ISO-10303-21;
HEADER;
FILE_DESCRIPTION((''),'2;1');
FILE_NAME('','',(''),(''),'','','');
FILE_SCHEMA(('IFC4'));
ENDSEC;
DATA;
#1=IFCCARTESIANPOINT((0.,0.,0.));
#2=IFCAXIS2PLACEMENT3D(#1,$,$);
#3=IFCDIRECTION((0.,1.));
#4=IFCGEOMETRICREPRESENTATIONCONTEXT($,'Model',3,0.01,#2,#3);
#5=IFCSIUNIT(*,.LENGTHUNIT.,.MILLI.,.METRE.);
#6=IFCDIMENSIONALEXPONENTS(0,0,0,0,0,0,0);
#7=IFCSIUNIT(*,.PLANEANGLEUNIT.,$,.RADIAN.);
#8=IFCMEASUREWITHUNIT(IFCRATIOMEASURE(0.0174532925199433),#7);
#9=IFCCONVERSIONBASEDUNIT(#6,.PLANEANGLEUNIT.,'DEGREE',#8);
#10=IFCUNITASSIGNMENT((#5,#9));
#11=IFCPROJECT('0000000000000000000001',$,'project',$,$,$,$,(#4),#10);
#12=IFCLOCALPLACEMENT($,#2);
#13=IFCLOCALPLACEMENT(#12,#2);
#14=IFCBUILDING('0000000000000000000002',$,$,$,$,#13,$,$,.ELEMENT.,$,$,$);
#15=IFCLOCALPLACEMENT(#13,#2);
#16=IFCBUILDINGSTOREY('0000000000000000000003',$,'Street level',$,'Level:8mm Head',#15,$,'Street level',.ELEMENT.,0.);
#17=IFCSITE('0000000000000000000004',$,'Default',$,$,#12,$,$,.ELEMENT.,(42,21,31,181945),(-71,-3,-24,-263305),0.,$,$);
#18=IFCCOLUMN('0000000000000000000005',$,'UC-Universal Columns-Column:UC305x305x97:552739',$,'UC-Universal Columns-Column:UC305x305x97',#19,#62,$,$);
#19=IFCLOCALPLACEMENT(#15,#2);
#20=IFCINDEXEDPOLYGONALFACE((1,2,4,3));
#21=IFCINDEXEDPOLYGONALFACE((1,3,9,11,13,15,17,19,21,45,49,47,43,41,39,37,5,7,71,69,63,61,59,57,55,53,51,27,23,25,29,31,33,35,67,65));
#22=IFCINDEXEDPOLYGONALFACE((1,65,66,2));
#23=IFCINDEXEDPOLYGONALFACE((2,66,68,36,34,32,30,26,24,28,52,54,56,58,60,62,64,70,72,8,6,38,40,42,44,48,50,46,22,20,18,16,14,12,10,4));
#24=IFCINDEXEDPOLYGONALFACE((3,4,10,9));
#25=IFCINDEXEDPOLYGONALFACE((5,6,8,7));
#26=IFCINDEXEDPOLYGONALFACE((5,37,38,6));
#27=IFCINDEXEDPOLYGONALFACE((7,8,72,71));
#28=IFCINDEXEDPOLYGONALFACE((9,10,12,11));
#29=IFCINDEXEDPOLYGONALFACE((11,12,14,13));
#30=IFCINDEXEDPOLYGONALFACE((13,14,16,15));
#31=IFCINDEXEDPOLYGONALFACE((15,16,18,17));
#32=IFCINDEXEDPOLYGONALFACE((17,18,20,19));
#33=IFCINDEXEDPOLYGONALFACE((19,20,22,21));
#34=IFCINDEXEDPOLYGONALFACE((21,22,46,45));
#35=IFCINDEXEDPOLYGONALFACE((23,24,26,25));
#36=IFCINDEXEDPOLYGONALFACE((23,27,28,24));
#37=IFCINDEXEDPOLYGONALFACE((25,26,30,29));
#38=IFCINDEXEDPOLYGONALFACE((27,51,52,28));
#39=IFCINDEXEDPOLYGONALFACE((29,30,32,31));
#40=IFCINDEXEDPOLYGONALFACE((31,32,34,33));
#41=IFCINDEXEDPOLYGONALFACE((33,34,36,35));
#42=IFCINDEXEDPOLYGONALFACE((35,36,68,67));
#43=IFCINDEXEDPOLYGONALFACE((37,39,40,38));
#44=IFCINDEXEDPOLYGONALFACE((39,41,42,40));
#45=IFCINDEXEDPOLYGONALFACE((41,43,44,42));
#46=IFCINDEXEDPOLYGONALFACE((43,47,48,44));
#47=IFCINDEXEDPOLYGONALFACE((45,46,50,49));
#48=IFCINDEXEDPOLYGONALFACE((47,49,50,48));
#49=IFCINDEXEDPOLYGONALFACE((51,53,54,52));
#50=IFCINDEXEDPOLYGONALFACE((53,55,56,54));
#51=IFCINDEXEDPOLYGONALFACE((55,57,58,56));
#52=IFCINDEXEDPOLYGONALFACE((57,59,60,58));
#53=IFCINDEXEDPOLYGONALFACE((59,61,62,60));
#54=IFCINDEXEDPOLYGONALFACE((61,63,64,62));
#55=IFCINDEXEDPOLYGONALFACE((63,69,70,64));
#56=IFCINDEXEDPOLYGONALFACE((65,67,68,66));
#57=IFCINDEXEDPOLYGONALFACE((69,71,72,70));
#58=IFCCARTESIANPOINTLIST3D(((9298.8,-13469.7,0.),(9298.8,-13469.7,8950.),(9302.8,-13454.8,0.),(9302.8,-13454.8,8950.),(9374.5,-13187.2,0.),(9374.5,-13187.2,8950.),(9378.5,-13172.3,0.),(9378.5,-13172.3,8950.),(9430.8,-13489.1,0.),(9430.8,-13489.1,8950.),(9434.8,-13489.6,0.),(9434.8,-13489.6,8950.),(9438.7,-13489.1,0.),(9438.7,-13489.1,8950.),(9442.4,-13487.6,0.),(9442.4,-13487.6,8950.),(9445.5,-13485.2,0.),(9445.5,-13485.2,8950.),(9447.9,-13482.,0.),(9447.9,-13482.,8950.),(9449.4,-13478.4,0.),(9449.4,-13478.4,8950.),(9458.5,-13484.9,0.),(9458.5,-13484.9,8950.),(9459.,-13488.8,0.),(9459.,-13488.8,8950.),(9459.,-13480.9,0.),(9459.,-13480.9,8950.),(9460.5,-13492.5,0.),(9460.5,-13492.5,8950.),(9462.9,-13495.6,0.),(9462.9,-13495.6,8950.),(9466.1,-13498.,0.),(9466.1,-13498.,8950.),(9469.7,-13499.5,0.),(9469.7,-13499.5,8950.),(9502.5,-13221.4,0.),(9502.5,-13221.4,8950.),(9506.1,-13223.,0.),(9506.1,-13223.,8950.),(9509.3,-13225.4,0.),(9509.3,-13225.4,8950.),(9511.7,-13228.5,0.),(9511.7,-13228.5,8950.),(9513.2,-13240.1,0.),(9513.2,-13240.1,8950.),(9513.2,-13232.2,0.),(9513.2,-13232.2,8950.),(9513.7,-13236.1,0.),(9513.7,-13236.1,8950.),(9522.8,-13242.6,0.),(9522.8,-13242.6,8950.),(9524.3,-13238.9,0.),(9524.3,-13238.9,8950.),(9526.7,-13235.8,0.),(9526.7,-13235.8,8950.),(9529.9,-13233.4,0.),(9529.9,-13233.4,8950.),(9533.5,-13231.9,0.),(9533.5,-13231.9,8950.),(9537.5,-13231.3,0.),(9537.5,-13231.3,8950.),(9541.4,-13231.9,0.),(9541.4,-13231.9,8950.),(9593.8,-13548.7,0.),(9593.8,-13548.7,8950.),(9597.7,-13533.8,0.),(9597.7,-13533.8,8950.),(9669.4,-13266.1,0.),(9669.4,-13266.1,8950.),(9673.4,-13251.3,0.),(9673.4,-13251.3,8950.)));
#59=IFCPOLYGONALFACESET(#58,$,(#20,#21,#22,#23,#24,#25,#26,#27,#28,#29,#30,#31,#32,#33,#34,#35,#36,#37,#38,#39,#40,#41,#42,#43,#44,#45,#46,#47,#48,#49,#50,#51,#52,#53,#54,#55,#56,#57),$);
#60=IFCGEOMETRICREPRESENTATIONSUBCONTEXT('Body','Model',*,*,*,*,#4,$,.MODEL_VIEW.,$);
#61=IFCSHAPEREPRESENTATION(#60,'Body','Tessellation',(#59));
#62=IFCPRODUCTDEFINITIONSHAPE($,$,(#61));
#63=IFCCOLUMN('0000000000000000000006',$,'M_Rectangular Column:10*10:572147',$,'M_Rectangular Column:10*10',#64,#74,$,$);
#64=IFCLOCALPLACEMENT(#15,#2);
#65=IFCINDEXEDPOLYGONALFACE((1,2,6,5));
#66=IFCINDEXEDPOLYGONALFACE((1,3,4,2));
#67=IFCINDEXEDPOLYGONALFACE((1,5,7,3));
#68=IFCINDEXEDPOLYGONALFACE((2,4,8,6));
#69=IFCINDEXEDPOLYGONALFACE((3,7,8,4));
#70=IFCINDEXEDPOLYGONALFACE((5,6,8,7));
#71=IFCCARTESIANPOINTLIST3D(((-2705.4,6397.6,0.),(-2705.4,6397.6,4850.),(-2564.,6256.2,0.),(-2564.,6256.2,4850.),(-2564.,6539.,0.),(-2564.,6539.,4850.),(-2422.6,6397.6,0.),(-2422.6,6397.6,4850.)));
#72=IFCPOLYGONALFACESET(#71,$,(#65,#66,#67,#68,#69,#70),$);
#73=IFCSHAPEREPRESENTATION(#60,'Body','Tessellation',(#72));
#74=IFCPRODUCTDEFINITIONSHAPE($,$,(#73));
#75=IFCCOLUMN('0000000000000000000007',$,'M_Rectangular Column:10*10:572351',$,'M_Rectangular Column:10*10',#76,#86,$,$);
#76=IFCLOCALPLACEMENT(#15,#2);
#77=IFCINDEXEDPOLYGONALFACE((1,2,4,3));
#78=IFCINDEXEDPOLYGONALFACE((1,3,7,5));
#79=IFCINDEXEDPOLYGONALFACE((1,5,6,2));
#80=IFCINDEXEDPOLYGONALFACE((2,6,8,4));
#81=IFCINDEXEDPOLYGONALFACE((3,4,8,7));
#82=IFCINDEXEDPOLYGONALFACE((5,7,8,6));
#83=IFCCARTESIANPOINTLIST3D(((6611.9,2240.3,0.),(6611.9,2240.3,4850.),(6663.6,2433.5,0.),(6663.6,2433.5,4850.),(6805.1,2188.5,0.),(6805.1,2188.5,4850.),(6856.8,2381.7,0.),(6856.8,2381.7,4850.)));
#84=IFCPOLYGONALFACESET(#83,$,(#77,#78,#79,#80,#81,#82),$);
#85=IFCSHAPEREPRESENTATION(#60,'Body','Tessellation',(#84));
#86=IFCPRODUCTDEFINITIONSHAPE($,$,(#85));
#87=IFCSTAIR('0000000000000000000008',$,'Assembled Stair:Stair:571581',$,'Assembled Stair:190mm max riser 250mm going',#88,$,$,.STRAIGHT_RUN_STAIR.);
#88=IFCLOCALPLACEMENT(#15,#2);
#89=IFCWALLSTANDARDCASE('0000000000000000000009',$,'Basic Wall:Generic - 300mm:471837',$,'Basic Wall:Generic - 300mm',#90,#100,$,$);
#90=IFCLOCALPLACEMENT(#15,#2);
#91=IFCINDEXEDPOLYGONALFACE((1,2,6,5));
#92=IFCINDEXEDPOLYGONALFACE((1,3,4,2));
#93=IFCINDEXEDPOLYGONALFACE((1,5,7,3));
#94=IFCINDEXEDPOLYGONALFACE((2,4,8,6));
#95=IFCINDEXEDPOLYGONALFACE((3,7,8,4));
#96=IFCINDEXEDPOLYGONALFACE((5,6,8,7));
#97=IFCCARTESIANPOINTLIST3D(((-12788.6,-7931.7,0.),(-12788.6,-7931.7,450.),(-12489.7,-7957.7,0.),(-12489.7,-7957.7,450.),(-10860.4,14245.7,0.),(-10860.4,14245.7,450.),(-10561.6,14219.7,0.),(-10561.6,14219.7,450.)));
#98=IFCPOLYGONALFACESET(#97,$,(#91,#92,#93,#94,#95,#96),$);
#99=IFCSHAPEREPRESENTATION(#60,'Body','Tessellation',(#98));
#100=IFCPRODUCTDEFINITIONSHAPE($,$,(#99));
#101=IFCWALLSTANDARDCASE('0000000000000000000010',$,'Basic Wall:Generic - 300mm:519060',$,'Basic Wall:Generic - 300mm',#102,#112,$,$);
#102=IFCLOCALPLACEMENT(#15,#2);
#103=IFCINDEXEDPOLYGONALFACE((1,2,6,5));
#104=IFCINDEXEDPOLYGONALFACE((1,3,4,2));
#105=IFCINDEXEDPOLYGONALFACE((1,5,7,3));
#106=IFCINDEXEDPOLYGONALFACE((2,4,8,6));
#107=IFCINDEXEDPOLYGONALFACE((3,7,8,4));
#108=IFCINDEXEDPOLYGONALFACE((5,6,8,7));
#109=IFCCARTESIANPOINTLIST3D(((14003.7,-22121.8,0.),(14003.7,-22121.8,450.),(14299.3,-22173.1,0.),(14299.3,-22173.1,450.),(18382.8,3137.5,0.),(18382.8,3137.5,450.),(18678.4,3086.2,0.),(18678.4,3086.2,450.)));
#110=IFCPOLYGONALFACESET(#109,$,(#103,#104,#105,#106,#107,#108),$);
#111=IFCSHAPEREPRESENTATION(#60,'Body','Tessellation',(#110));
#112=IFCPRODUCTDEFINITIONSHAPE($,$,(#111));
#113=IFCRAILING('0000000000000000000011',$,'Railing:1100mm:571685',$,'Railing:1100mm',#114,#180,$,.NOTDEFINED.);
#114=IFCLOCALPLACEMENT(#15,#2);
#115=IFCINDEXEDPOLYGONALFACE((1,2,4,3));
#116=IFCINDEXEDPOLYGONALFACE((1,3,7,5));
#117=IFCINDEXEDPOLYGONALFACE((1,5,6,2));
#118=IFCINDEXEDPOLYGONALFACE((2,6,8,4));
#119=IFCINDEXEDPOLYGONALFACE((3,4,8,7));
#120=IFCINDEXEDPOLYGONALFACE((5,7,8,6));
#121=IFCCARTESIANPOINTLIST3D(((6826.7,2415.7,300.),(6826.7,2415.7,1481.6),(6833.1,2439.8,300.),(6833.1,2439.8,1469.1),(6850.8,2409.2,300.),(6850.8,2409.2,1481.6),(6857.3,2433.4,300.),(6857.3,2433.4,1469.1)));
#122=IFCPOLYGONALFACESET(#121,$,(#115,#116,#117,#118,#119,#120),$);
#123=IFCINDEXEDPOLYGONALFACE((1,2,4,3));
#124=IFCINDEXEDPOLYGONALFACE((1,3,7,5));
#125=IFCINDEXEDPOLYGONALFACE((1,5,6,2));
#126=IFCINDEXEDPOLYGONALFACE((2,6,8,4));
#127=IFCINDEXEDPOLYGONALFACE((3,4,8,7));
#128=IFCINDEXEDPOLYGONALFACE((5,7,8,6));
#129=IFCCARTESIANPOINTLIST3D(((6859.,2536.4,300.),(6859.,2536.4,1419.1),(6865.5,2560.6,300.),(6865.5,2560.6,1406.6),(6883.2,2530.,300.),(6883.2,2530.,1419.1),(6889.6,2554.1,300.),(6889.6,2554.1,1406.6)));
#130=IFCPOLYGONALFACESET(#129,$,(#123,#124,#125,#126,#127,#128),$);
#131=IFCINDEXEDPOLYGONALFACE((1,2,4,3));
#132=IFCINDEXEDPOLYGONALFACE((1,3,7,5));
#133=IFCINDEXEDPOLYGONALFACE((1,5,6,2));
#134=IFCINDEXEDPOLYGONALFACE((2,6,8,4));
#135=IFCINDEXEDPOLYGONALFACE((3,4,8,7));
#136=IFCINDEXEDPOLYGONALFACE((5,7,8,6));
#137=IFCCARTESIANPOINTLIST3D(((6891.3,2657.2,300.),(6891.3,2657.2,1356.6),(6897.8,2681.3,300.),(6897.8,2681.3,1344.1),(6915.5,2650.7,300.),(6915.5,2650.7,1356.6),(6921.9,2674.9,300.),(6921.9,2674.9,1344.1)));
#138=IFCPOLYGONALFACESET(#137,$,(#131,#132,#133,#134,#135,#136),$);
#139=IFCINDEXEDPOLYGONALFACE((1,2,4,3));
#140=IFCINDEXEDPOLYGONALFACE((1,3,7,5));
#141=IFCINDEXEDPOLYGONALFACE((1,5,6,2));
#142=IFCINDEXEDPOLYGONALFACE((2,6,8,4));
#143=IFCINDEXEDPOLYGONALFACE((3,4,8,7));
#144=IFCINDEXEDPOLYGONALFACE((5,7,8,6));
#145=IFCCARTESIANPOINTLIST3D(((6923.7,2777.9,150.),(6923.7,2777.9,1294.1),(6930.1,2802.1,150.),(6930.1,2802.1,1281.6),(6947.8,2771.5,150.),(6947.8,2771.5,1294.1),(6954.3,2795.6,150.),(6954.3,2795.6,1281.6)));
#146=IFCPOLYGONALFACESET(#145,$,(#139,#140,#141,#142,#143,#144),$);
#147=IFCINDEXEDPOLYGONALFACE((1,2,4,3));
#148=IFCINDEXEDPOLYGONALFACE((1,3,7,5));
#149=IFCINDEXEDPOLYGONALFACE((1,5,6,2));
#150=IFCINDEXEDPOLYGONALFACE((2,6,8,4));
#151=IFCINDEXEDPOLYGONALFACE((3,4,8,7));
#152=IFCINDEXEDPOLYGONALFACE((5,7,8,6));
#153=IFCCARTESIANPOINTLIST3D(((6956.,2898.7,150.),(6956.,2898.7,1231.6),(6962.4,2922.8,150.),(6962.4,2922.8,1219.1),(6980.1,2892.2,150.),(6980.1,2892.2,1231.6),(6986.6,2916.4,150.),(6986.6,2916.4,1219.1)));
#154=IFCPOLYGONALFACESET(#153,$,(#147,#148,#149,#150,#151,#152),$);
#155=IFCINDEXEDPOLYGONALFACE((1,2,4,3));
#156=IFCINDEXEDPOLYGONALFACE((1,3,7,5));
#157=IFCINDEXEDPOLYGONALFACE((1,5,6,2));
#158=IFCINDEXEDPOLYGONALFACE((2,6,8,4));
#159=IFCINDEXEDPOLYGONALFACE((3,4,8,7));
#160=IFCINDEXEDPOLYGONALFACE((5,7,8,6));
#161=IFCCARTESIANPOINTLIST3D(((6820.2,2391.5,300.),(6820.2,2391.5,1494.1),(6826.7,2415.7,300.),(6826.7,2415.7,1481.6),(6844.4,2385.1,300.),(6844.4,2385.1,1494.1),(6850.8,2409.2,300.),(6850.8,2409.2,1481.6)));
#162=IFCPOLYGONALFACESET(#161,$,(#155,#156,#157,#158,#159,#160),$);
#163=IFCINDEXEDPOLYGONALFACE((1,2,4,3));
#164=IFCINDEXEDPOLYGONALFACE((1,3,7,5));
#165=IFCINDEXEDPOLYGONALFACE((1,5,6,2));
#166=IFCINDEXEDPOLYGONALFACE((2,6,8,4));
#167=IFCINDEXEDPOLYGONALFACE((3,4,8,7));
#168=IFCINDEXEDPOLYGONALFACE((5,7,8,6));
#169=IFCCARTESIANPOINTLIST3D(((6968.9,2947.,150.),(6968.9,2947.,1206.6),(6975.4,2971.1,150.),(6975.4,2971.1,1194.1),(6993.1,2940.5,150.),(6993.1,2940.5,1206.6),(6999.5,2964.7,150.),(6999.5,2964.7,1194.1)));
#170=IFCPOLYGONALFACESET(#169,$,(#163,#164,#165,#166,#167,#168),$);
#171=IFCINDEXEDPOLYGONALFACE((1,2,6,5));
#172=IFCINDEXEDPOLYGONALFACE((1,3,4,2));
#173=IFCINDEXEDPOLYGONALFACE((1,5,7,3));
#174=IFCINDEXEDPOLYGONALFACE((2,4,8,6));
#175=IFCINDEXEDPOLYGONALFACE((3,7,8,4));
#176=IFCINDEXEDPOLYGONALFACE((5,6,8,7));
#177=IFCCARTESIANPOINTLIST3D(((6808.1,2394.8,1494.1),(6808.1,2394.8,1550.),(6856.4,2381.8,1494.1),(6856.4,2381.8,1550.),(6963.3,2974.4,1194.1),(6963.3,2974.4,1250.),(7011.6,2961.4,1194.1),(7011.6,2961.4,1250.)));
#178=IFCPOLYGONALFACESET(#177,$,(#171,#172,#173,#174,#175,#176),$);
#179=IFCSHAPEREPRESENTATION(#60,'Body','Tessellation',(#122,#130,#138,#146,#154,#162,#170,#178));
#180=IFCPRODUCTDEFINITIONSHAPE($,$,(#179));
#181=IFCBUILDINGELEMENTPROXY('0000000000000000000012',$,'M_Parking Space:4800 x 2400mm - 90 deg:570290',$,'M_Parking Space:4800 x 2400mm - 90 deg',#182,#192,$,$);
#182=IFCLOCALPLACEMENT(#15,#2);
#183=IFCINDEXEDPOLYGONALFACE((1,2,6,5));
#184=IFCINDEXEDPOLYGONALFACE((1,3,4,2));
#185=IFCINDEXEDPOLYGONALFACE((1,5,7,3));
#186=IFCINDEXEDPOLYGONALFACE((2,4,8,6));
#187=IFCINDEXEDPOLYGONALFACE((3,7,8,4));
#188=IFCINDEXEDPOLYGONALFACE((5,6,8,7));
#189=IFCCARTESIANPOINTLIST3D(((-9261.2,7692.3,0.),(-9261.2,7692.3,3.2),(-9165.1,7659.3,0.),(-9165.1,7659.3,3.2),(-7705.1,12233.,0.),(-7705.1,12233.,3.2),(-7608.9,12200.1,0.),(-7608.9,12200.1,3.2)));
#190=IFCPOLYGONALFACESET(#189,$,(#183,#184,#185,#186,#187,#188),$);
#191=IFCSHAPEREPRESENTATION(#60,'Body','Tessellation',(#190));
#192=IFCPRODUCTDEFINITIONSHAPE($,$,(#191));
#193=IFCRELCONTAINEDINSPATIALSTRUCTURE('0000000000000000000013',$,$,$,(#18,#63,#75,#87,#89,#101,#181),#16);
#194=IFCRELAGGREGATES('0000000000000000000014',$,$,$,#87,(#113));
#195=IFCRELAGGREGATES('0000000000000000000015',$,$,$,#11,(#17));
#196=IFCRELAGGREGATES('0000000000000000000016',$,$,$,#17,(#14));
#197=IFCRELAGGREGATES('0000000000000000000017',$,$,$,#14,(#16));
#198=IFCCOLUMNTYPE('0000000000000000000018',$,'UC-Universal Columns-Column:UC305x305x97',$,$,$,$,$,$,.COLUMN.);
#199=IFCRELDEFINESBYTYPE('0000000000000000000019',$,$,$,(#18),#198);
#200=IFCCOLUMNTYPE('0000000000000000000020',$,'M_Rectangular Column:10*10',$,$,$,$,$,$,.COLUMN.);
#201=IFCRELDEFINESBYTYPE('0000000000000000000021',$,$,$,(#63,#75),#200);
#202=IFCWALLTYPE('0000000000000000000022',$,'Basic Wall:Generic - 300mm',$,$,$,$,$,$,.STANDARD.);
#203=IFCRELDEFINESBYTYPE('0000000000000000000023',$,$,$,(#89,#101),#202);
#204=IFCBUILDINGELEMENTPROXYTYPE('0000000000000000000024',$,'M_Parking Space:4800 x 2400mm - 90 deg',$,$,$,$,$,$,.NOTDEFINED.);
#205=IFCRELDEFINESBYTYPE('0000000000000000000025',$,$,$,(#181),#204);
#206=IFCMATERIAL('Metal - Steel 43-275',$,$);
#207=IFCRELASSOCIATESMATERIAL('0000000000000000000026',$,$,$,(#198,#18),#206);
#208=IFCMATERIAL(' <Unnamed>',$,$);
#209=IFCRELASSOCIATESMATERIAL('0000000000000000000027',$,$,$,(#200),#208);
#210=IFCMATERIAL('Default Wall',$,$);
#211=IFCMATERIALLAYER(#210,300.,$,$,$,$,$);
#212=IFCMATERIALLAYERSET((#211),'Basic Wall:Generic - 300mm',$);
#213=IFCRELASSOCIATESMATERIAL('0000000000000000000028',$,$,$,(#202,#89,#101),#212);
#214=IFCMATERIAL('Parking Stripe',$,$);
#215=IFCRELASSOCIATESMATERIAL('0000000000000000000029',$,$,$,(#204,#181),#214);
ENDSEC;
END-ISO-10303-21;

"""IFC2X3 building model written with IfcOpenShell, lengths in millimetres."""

from ifc_helpers import new_model, entity, si_unit, converted_unit, direction, frame, frame_2d, origin, origin_2d_with_axis, place, context, subcontext, project, spatial, polyline, rectangle, i_section, outline, extrude, source, transform, mapped, material, layer, layer_set, layer_usage, type_object, type_shapes, element, aggregate, save


model = new_model("IFC2X3")

# Units and contexts
model_context = context("Model", 3, precision=0.01, world=origin(), true_north=direction((0.0, 1.0)))
body_context = subcontext(model_context, "Body", "Model", "MODEL_VIEW")
ifc_project = project(units=[si_unit("LENGTHUNIT", "METRE", prefix="MILLI"), converted_unit("PLANEANGLEUNIT", "DEGREE", entity("IfcRatioMeasure", 0.0174532925199433), si_unit("PLANEANGLEUNIT", "RADIAN"), dimensions=[0, 0, 0, 0, 0, 0, 0])], contexts=[model_context])

# Site, building, storey
site_placement = place(None, origin())
site = spatial("IfcSite", under=ifc_project, at=site_placement, Name="Default", CompositionType="ELEMENT", RefLatitude=(42, 21, 31, 181945), RefLongitude=(-71, -3, -24, -263305), RefElevation=0.0)
building_placement = place(site_placement, origin())
building = spatial("IfcBuilding", under=site, at=building_placement, CompositionType="ELEMENT")
storey_placement = place(building_placement, origin())
storey = spatial("IfcBuildingStorey", under=building, at=storey_placement, Name="Street level", ObjectType="Level:8mm Head", LongName="Street level", CompositionType="ELEMENT", Elevation=0.0)

# Columns
ifc_material_1 = material(Name="Metal - Steel 43-275")
column_type_1 = type_object("IfcColumnType", Name="UC-Universal Columns-Column:UC305x305x97", PredefinedType="COLUMN", material=ifc_material_1)
shared_shape_1 = source(origin(), body_context, "Body", "SweptSolid", [
    extrude(i_section(OverallWidth=305.3, OverallDepth=307.9, WebThickness=9.9, FlangeThickness=15.4, FilletRadius=15.2, at=frame_2d((0.0, 0.0), x_axis=(0.0, 1.0))), frame((0.0, 0.0, 0.0), z_axis=(0.0, 0.0, 1.0), x_axis=(0.0, -1.0, 0.0)), (0.0, 0.0, 1.0), 8950.0),
])
type_shapes(column_type_1, [shared_shape_1])
column_placement = place(storey_placement, frame((9486.1, -13360.5, 0.0), z_axis=(0.0, 0.0, 1.0), x_axis=(0.965983, -0.258607, 0.0)))
element("IfcColumn", 1, at=column_placement, inside=storey, type_object=column_type_1, material=ifc_material_1, Name="UC-Universal Columns-Column:UC305x305x97:552739", ObjectType="UC-Universal Columns-Column:UC305x305x97", context=body_context, shape_type="MappedRepresentation", body=[
    mapped(shared_shape_1, transform((0.0, 0.0, 0.0), scale=1.0)),
])
ifc_material_2 = material(Name=" <Unnamed>")
column_type_2 = type_object("IfcColumnType", Name="M_Rectangular Column:10*10", PredefinedType="COLUMN", material=ifc_material_2)
shared_shape_2 = source(origin(), body_context, "Body", "SweptSolid", [
    extrude(rectangle(XDim=200.0, YDim=200.0, at=origin_2d_with_axis()), frame((0.0, 0.0, 0.0), z_axis=(0.0, 0.0, 1.0), x_axis=(0.0, -1.0, 0.0)), (0.0, 0.0, 1.0), 4850.0),
])
type_shapes(column_type_2, [shared_shape_2])
for number, where, z_axis, x_axis, name in (
    (2, (-2564.0, 6397.6, 0.0), (0.0, 0.0, 1.0), (0.707107, 0.707107, 0.0), "M_Rectangular Column:10*10:572147"),
    (3, (6734.4, 2311.0, 0.0), (0.0, 0.0, 1.0), (0.258607, 0.965983, 0.0), "M_Rectangular Column:10*10:572351"),
):
    element("IfcColumn", number, at=place(storey_placement, frame(where, z_axis=z_axis, x_axis=x_axis)), inside=storey, type_object=column_type_2, Name=name, ObjectType="M_Rectangular Column:10*10", context=body_context, shape_type="MappedRepresentation", body=[
        mapped(shared_shape_2, transform((0.0, 0.0, 0.0), scale=1.0)),
    ])

# Stair
stair_placement = place(storey_placement, origin())
stair = element("IfcStair", 4, at=stair_placement, inside=storey, Name="Assembled Stair:Stair:571581", ObjectType="Assembled Stair:190mm max riser 250mm going", ShapeType="STRAIGHT_RUN_STAIR")

# Walls
ifc_material_3 = material(Name="Default Wall")
ifc_layer_1 = layer(ifc_material_3, 300.0)
ifc_layer_set_1 = layer_set([ifc_layer_1], Name="Basic Wall:Generic - 300mm")
ifc_layer_usage_1 = layer_usage(ifc_layer_set_1, "AXIS2", "NEGATIVE", 150.0)
wall_type = type_object("IfcWallType", Name="Basic Wall:Generic - 300mm", PredefinedType="STANDARD", material=ifc_layer_set_1)
wall_1_placement = place(storey_placement, frame((-10711.0, 14232.7, 0.0), z_axis=(0.0, 0.0, 1.0), x_axis=(-0.086615, -0.996242, 0.0)))
element("IfcWallStandardCase", 5, at=wall_1_placement, inside=storey, type_object=wall_type, material=ifc_layer_usage_1, Name="Basic Wall:Generic - 300mm:471837", ObjectType="Basic Wall:Generic - 300mm", context=body_context, shape_type="SweptSolid", body=[
    extrude(rectangle(XDim=22261.1, YDim=300.0, at=frame_2d((11130.5, 0.0), x_axis=(-1.0, 0.0))), origin(), (0.0, 0.0, 1.0), 450.0),
])
ifc_layer_usage_2 = layer_usage(ifc_layer_set_1, "AXIS2", "NEGATIVE", 150.0)
wall_2_placement = place(storey_placement, frame((14151.5, -22147.4, 0.0), z_axis=(0.0, 0.0, 1.0), x_axis=(0.17082, 0.985302, 0.0)))
element("IfcWallStandardCase", 6, at=wall_2_placement, inside=storey, type_object=wall_type, material=ifc_layer_usage_2, Name="Basic Wall:Generic - 300mm:519060", ObjectType="Basic Wall:Generic - 300mm", context=body_context, shape_type="SweptSolid", body=[
    extrude(rectangle(XDim=25636.1, YDim=300.0, at=frame_2d((12818.0, 0.0), x_axis=(-1.0, 0.0))), origin(), (0.0, 0.0, 1.0), 450.0),
])

# Railing
railing_placement = place(stair_placement, origin())
railing = element("IfcRailing", 7, at=railing_placement, Name="Railing:1100mm:571685", ObjectType="Railing:1100mm", PredefinedType="NOTDEFINED", context=body_context, shape_type="SweptSolid", body=[
    extrude(outline(polyline([(-587.7, -12.5), (581.4, -12.5), (593.9, 12.5), (-587.7, 12.5), (-587.7, -12.5)])), frame((6829.9, 2427.8, 887.7), z_axis=(0.965983, -0.258606, 0.0), x_axis=(0.0, 0.0, 1.0)), (0.0, 0.0, 1.0), 25.0),
    extrude(outline(polyline([(-556.4, -12.5), (550.2, -12.5), (562.7, 12.5), (-556.4, 12.5), (-556.4, -12.5)])), frame((6862.2, 2548.5, 856.4), z_axis=(0.965983, -0.258606, 0.0), x_axis=(0.0, 0.0, 1.0)), (0.0, 0.0, 1.0), 25.0),
    extrude(outline(polyline([(-525.2, -12.5), (518.9, -12.5), (531.4, 12.5), (-525.2, 12.5), (-525.2, -12.5)])), frame((6894.6, 2669.3, 825.2), z_axis=(0.965983, -0.258606, 0.0), x_axis=(0.0, 0.0, 1.0)), (0.0, 0.0, 1.0), 25.0),
    extrude(outline(polyline([(-568.9, -12.5), (562.7, -12.5), (575.2, 12.5), (-568.9, 12.5), (-568.9, -12.5)])), frame((6926.9, 2790.0, 718.9), z_axis=(0.965983, -0.258606, 0.0), x_axis=(0.0, 0.0, 1.0)), (0.0, 0.0, 1.0), 25.0),
    extrude(outline(polyline([(-537.7, -12.5), (531.4, -12.5), (543.9, 12.5), (-537.7, 12.5), (-537.7, -12.5)])), frame((6959.2, 2910.8, 687.7), z_axis=(0.965983, -0.258606, 0.0), x_axis=(0.0, 0.0, 1.0)), (0.0, 0.0, 1.0), 25.0),
    extrude(outline(polyline([(-593.9, -12.5), (587.7, -12.5), (600.2, 12.5), (-593.9, 12.5), (-593.9, -12.5)])), frame((6823.4, 2403.6, 893.9), z_axis=(0.965983, -0.258606, 0.0), x_axis=(0.0, 0.0, 1.0)), (0.0, 0.0, 1.0), 25.0),
    extrude(outline(polyline([(-525.2, -12.5), (518.9, -12.5), (531.4, 12.5), (-525.2, 12.5), (-525.2, -12.5)])), frame((6972.1, 2959.1, 675.2), z_axis=(0.965983, -0.258606, 0.0), x_axis=(0.0, 0.0, 1.0)), (0.0, 0.0, 1.0), 25.0),
    extrude(outline(polyline([(-322.9, -25.0), (347.9, -25.0), (322.9, 25.0), (-347.9, 25.0), (-322.9, -25.0)])), frame((6885.7, 2684.6, 1372.0), z_axis=(0.965983, -0.258606, 0.0), x_axis=(-0.231304, -0.864001, 0.447214)), (0.0, 0.0, 1.0), 50.0),
])
aggregate(stair, [railing])

# Building element proxy
ifc_material_4 = material(Name="Parking Stripe")
building_element_proxy_type = type_object("IfcBuildingElementProxyType", Name="M_Parking Space:4800 x 2400mm - 90 deg", PredefinedType="NOTDEFINED", material=ifc_material_4)
shared_shape_3 = source(origin(), body_context, "Body", "SweptSolid", [
    extrude(rectangle(XDim=101.6, YDim=4800.0, at=origin_2d_with_axis()), frame((0.0, 2400.0, 0.0)), (0.0, 0.0, 1.0), 3.2),
])
type_shapes(building_element_proxy_type, [shared_shape_3])
for number, where, z_axis, x_axis, name in (
    (8, (-9213.1, 7675.8, 0.0), (0.0, 0.0, 1.0), (0.945989, -0.324198, 0.0), "M_Parking Space:4800 x 2400mm - 90 deg:570290"),
):
    element("IfcBuildingElementProxy", number, at=place(storey_placement, frame(where, z_axis=z_axis, x_axis=x_axis)), inside=storey, type_object=building_element_proxy_type, material=ifc_material_4, Name=name, ObjectType="M_Parking Space:4800 x 2400mm - 90 deg", context=body_context, shape_type="MappedRepresentation", body=[
        mapped(shared_shape_3, transform((0.0, 0.0, 0.0), scale=1.0)),
    ])

save(model, "model.ifc")
